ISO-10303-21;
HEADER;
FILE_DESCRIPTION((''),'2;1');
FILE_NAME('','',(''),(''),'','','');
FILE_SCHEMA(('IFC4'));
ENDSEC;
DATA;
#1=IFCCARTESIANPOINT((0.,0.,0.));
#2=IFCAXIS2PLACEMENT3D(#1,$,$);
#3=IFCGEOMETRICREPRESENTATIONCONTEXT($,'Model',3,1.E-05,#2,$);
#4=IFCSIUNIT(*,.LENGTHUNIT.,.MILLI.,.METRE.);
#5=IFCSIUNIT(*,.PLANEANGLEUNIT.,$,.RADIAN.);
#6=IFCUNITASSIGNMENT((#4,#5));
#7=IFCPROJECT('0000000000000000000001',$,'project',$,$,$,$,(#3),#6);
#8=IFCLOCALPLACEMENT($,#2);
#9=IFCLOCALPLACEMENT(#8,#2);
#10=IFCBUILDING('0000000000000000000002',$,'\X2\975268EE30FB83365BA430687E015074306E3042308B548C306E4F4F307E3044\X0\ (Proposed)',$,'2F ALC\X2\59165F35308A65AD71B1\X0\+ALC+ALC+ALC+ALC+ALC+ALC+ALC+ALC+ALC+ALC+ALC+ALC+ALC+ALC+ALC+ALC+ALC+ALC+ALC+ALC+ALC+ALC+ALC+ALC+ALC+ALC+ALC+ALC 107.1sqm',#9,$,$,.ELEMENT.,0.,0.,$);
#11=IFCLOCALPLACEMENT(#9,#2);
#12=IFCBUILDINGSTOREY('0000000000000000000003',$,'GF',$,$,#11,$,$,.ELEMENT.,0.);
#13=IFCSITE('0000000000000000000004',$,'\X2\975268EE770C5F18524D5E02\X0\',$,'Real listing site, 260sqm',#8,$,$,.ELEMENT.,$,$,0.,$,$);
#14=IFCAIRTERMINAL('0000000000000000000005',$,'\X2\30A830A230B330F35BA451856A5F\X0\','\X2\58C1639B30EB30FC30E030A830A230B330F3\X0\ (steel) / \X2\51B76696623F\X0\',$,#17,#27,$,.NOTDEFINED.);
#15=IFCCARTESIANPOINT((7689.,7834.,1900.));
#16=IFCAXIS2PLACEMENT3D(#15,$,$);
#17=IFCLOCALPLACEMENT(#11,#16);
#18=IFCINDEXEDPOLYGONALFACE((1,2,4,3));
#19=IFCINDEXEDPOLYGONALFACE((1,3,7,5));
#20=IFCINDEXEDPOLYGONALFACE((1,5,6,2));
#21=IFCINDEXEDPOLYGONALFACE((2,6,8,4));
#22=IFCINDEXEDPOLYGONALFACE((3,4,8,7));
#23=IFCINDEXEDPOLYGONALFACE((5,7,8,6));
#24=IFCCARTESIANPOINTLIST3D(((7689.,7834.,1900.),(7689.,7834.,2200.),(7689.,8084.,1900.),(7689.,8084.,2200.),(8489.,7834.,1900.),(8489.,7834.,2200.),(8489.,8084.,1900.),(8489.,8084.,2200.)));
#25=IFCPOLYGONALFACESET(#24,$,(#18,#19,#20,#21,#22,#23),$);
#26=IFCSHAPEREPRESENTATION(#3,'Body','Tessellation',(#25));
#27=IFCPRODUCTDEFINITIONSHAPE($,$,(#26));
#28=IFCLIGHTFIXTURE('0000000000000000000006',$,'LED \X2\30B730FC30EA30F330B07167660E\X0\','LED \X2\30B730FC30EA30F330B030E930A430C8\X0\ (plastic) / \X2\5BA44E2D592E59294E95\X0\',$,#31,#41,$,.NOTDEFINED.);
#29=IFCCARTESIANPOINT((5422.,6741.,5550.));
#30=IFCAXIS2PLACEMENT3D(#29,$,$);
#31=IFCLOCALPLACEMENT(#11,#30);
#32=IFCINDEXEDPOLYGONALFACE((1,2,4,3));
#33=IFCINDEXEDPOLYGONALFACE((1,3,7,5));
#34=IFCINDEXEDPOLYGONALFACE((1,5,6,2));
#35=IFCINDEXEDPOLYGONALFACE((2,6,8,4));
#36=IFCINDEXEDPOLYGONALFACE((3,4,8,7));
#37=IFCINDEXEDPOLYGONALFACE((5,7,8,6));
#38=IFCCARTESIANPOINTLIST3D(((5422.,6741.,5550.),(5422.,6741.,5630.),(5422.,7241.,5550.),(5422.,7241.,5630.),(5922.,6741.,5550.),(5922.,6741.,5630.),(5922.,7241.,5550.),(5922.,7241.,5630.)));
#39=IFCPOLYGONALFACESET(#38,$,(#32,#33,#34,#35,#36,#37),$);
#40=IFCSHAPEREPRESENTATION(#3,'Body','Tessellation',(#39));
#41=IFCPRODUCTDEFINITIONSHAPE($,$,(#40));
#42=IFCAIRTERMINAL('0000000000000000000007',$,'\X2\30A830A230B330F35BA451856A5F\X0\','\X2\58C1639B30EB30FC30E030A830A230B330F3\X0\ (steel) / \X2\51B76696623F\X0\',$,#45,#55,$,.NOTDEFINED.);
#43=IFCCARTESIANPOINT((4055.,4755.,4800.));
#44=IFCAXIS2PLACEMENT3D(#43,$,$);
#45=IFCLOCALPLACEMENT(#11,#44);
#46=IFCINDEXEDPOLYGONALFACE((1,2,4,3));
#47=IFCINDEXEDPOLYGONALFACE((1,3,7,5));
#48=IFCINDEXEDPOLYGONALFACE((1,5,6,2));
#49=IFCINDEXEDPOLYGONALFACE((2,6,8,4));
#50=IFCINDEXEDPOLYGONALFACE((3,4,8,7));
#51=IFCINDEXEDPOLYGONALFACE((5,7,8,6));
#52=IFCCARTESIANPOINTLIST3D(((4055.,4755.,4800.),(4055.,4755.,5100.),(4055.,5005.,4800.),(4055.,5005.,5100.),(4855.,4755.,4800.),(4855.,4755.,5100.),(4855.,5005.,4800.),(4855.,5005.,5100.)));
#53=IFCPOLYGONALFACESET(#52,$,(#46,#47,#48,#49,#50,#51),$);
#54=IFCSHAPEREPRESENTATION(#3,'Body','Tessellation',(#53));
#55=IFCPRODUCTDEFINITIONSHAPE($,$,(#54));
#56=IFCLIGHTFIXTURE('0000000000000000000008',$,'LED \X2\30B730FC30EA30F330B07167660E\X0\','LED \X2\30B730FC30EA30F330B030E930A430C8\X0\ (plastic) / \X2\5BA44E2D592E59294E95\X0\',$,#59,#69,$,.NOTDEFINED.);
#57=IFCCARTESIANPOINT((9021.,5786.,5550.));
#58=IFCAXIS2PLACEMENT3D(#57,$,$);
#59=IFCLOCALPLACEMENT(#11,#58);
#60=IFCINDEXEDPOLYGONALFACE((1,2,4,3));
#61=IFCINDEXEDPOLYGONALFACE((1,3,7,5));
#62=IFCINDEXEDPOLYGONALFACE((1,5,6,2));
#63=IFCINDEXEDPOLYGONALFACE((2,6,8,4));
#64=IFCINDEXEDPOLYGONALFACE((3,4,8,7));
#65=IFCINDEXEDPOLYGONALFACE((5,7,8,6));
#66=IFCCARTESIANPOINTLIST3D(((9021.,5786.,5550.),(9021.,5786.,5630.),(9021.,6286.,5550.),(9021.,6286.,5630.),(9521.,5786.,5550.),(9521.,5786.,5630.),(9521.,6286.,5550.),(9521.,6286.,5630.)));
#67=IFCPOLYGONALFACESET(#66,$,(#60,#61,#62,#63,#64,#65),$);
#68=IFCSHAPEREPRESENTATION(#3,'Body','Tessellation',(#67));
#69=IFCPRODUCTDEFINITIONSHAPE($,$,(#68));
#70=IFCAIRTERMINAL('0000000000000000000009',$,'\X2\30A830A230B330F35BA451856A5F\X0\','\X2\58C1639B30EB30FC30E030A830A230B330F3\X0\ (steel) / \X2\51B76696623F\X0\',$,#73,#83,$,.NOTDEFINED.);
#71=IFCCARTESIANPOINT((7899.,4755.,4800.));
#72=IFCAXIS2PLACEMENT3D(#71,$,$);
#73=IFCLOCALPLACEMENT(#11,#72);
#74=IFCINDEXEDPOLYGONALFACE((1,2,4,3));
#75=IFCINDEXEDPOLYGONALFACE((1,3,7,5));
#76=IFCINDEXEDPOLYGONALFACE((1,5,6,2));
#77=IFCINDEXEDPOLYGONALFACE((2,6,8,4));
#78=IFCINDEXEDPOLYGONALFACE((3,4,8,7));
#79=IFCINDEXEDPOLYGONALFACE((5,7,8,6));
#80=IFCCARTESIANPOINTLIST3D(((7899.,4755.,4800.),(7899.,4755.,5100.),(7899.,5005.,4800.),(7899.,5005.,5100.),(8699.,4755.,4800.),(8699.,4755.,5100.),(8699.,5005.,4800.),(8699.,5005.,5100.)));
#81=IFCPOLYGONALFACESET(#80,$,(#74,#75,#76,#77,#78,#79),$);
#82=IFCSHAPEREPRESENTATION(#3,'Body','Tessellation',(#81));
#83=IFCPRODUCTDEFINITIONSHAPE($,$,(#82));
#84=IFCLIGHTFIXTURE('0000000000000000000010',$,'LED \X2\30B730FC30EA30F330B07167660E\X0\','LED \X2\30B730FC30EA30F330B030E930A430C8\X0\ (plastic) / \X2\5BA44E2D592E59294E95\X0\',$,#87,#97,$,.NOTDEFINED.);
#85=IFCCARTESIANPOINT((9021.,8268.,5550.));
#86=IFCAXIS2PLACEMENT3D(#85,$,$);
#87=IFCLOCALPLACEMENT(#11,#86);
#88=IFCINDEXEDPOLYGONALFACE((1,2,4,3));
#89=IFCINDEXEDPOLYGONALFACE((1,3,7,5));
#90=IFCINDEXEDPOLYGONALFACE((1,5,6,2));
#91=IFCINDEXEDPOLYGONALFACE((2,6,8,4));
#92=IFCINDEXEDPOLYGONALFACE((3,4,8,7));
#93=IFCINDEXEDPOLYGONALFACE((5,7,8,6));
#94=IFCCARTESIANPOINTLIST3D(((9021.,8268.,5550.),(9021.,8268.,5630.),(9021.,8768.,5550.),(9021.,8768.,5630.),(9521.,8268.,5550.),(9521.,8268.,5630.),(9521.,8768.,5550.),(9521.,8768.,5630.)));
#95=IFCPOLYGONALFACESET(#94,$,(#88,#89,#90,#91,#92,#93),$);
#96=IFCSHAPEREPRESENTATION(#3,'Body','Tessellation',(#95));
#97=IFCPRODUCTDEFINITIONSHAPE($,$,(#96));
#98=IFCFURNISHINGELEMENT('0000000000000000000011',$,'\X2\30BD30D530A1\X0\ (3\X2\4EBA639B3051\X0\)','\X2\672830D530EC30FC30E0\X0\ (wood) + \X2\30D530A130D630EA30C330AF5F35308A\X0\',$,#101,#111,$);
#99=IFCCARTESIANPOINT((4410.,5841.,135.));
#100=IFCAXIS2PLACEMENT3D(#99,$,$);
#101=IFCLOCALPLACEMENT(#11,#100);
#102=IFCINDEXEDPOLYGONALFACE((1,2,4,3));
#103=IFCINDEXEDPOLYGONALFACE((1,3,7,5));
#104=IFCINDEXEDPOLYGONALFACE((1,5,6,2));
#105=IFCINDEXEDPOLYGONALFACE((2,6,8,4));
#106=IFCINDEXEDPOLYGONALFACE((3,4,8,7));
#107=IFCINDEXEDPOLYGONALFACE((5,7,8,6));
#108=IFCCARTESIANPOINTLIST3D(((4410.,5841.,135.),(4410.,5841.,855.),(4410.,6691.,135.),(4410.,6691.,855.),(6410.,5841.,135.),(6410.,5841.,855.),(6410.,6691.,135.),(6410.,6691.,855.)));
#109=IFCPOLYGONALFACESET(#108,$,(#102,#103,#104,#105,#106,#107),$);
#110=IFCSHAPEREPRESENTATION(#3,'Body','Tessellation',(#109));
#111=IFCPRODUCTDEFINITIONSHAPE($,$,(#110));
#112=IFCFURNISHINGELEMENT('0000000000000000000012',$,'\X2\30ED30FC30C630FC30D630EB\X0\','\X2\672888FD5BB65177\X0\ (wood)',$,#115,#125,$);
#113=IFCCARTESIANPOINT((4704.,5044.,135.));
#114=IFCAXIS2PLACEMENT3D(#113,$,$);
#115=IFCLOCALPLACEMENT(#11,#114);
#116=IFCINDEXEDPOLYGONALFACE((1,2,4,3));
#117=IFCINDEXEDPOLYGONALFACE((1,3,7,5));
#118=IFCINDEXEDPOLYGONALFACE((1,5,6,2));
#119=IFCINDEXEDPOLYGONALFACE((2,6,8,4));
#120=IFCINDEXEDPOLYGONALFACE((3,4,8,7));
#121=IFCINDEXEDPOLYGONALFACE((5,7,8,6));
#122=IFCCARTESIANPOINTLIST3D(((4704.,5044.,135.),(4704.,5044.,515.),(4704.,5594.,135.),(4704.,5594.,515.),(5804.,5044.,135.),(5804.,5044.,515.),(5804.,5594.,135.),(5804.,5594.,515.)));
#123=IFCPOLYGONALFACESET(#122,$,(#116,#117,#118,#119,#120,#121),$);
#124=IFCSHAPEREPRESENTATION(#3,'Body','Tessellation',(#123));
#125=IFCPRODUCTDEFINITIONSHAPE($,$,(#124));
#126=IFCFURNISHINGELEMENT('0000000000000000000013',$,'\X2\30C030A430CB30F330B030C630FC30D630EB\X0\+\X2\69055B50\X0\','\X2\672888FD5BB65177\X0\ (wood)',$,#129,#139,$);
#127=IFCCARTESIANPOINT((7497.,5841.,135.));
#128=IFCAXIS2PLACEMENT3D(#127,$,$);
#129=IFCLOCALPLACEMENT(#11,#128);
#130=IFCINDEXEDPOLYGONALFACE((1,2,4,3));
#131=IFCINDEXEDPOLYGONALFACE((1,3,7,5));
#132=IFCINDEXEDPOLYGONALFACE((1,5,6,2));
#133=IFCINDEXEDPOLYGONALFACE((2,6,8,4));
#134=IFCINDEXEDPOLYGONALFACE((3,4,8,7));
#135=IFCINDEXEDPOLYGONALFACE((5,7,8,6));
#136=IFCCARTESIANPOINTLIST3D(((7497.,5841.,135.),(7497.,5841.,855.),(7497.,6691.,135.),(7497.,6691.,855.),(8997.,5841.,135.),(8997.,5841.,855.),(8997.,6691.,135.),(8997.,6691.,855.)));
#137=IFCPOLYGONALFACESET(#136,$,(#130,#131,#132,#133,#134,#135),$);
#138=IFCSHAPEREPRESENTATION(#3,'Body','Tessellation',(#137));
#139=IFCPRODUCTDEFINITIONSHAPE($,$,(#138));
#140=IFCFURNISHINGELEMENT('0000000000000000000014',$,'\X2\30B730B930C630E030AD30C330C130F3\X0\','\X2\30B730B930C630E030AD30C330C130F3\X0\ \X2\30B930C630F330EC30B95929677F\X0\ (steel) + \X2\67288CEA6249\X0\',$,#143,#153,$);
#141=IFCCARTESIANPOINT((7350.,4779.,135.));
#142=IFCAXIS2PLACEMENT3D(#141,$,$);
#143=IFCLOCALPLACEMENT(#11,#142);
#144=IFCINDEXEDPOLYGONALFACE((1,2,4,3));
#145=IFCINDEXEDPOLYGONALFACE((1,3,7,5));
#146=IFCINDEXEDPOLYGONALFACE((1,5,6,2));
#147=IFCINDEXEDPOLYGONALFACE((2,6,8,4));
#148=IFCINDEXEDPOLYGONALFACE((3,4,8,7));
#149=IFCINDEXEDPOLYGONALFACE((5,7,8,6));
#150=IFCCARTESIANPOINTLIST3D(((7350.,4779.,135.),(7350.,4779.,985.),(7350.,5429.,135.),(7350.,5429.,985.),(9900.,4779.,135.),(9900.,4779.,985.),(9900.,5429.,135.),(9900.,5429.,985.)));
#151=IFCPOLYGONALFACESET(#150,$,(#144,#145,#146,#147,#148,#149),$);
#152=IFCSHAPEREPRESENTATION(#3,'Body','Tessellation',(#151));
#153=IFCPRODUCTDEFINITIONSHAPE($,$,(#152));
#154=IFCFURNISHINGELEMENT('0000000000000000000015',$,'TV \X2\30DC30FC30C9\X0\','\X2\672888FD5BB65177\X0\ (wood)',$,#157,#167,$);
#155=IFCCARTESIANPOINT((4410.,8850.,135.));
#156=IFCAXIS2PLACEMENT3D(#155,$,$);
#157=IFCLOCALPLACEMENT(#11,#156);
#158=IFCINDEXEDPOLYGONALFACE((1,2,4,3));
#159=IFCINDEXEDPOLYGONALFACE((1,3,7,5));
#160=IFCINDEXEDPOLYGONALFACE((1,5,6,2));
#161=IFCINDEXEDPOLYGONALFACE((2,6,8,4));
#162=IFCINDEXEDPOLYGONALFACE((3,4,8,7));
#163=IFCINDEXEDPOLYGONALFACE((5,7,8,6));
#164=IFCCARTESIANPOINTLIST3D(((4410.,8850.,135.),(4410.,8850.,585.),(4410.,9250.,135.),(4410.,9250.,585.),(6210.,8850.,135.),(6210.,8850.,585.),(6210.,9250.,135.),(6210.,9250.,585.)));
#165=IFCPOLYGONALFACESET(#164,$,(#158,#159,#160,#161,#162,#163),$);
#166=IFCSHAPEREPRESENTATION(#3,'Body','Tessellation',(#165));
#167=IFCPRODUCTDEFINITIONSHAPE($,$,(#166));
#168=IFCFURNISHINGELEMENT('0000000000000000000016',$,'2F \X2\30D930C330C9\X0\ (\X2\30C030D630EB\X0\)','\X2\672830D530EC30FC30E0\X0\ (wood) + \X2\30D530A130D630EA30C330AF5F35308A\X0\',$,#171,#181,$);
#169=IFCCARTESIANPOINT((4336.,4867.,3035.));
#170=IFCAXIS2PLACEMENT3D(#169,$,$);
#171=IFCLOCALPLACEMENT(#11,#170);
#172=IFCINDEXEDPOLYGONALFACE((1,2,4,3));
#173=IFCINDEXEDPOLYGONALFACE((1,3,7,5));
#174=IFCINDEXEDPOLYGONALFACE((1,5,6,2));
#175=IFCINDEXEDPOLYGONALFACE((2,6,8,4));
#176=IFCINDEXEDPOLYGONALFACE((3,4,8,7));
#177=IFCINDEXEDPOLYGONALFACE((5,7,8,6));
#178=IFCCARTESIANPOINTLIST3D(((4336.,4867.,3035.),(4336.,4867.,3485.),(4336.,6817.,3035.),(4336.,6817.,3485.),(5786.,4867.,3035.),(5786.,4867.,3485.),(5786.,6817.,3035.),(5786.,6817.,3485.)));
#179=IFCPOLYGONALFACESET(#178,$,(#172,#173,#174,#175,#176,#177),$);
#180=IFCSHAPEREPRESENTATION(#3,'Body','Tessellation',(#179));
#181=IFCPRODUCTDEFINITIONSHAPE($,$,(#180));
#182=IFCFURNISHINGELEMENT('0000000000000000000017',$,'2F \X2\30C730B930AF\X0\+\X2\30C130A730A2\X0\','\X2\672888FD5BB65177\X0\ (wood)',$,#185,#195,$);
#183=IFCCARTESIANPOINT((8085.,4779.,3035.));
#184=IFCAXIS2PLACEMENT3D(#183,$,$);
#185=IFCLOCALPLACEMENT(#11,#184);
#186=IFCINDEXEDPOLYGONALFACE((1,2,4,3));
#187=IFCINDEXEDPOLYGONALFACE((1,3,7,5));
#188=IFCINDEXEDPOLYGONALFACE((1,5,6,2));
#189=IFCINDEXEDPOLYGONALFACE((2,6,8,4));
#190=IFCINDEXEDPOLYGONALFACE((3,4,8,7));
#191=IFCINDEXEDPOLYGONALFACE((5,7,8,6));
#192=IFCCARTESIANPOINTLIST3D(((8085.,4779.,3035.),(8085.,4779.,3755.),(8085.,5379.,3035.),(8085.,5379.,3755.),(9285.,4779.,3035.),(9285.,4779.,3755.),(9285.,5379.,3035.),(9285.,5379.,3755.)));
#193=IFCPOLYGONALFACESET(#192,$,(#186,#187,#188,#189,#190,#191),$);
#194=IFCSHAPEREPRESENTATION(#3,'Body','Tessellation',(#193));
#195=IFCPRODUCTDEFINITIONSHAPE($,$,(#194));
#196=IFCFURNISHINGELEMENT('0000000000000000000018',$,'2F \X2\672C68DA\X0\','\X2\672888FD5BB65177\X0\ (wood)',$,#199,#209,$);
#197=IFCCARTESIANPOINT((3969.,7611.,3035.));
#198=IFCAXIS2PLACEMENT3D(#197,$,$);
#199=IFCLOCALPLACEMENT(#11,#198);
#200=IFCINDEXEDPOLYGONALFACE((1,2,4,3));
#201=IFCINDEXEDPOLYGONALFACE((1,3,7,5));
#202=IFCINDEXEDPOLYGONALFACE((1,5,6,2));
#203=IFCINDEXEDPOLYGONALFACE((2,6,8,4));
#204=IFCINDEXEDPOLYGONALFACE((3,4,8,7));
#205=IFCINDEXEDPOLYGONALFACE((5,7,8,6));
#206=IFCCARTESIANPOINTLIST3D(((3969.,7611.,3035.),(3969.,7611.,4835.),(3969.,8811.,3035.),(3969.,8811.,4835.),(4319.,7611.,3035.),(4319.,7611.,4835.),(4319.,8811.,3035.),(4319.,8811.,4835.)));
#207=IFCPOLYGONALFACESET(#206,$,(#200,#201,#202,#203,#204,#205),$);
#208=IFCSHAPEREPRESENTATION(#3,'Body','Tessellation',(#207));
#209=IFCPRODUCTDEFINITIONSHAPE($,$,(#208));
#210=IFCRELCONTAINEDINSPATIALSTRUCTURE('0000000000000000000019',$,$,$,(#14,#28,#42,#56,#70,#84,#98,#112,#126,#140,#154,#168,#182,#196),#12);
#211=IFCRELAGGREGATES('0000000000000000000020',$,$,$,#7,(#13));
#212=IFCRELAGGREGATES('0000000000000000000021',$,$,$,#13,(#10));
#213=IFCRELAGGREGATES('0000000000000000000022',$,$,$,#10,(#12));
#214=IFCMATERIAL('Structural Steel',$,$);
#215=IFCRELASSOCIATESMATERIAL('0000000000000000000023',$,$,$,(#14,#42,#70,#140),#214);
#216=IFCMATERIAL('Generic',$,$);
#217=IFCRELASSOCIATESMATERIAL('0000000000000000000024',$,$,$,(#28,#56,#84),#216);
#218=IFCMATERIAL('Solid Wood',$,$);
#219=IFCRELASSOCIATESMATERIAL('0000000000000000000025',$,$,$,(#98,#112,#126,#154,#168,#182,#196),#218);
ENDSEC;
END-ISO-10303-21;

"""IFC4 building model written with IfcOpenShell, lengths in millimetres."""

from ifc_helpers import new_model, si_unit, frame, frame_2d, origin, place, context, project, spatial, rectangle, extrude, material, element, save


model = new_model("IFC4")

# Units and contexts
model_context = context("Model", 3, precision=1e-05, world=origin())
ifc_project = project(units=[si_unit("LENGTHUNIT", "METRE", prefix="MILLI"), si_unit("PLANEANGLEUNIT", "RADIAN")], contexts=[model_context])

# Site, building, storey
site_placement = place(None, origin())
site = spatial("IfcSite", under=ifc_project, at=site_placement, Name="青森県弘前市", ObjectType="Real listing site, 260sqm", CompositionType="ELEMENT", RefElevation=0.0)
building_placement = place(site_placement, origin())
building = spatial("IfcBuilding", under=site, at=building_placement, Name="青森・茶室と縁側のある和の住まい (Proposed)", ObjectType="2F ALC外張り断熱+ALC+ALC+ALC+ALC+ALC+ALC+ALC+ALC+ALC+ALC+ALC+ALC+ALC+ALC+ALC+ALC+ALC+ALC+ALC+ALC+ALC+ALC+ALC+ALC+ALC+ALC+ALC+ALC 107.1sqm", CompositionType="ELEMENT", ElevationOfRefHeight=0.0, ElevationOfTerrain=0.0)
storey_placement = place(building_placement, origin())
storey = spatial("IfcBuildingStorey", under=building, at=storey_placement, Name="GF", CompositionType="ELEMENT", Elevation=0.0)

# Shared definitions
ifc_material_1 = material(Name="Solid Wood")

# Shared definitions
ifc_material_2 = material(Name="Structural Steel")

# Shared definitions
ifc_material_3 = material(Name="Generic")

# Air terminal
air_terminal_1_placement = place(storey_placement, frame((7689.0, 7834.0, 1900.0)))
element("IfcAirTerminal", 1, at=air_terminal_1_placement, inside=storey, material=ifc_material_2, Name="エアコン室内機", Description="壁掛ルームエアコン (steel) / 冷暖房", PredefinedType="NOTDEFINED", context=model_context, shape_type="SweptSolid", body=[
    extrude(rectangle(XDim=800.0, YDim=250.0, at=frame_2d((400.0, 125.0))), frame((7689.0, 7834.0, 1900.0)), (0.0, 0.0, 1.0), 300.0),
])

# Light fixture
light_fixture_1_placement = place(storey_placement, frame((5422.0, 6741.0, 5550.0)))
element("IfcLightFixture", 2, at=light_fixture_1_placement, inside=storey, material=ifc_material_3, Name="LED シーリング照明", Description="LED シーリングライト (plastic) / 室中央天井", PredefinedType="NOTDEFINED", context=model_context, shape_type="SweptSolid", body=[
    extrude(rectangle(XDim=500.0, YDim=500.0, at=frame_2d((250.0, 250.0))), frame((5422.0, 6741.0, 5550.0)), (0.0, 0.0, 1.0), 80.0),
])

# Air terminal
air_terminal_2_placement = place(storey_placement, frame((4055.0, 4755.0, 4800.0)))
element("IfcAirTerminal", 3, at=air_terminal_2_placement, inside=storey, material=ifc_material_2, Name="エアコン室内機", Description="壁掛ルームエアコン (steel) / 冷暖房", PredefinedType="NOTDEFINED", context=model_context, shape_type="SweptSolid", body=[
    extrude(rectangle(XDim=800.0, YDim=250.0, at=frame_2d((400.0, 125.0))), frame((4055.0, 4755.0, 4800.0)), (0.0, 0.0, 1.0), 300.0),
])

# Light fixture
light_fixture_2_placement = place(storey_placement, frame((9021.0, 5786.0, 5550.0)))
element("IfcLightFixture", 4, at=light_fixture_2_placement, inside=storey, material=ifc_material_3, Name="LED シーリング照明", Description="LED シーリングライト (plastic) / 室中央天井", PredefinedType="NOTDEFINED", context=model_context, shape_type="SweptSolid", body=[
    extrude(rectangle(XDim=500.0, YDim=500.0, at=frame_2d((250.0, 250.0))), frame((9021.0, 5786.0, 5550.0)), (0.0, 0.0, 1.0), 80.0),
])

# Air terminal
air_terminal_3_placement = place(storey_placement, frame((7899.0, 4755.0, 4800.0)))
element("IfcAirTerminal", 5, at=air_terminal_3_placement, inside=storey, material=ifc_material_2, Name="エアコン室内機", Description="壁掛ルームエアコン (steel) / 冷暖房", PredefinedType="NOTDEFINED", context=model_context, shape_type="SweptSolid", body=[
    extrude(rectangle(XDim=800.0, YDim=250.0, at=frame_2d((400.0, 125.0))), frame((7899.0, 4755.0, 4800.0)), (0.0, 0.0, 1.0), 300.0),
])

# Light fixture
light_fixture_3_placement = place(storey_placement, frame((9021.0, 8268.0, 5550.0)))
element("IfcLightFixture", 6, at=light_fixture_3_placement, inside=storey, material=ifc_material_3, Name="LED シーリング照明", Description="LED シーリングライト (plastic) / 室中央天井", PredefinedType="NOTDEFINED", context=model_context, shape_type="SweptSolid", body=[
    extrude(rectangle(XDim=500.0, YDim=500.0, at=frame_2d((250.0, 250.0))), frame((9021.0, 8268.0, 5550.0)), (0.0, 0.0, 1.0), 80.0),
])

# Furnishing elements
furnishing_1_placement = place(storey_placement, frame((4410.0, 5841.0, 135.0)))
element("IfcFurnishingElement", 7, at=furnishing_1_placement, inside=storey, material=ifc_material_1, Name="ソファ (3人掛け)", Description="木フレーム (wood) + ファブリック張り", context=model_context, shape_type="SweptSolid", body=[
    extrude(rectangle(XDim=2000.0, YDim=850.0, at=frame_2d((1000.0, 425.0))), frame((4410.0, 5841.0, 135.0)), (0.0, 0.0, 1.0), 720.0),
])
furnishing_2_placement = place(storey_placement, frame((4704.0, 5044.0, 135.0)))
element("IfcFurnishingElement", 8, at=furnishing_2_placement, inside=storey, material=ifc_material_1, Name="ローテーブル", Description="木製家具 (wood)", context=model_context, shape_type="SweptSolid", body=[
    extrude(rectangle(XDim=1100.0, YDim=550.0, at=frame_2d((550.0, 275.0))), frame((4704.0, 5044.0, 135.0)), (0.0, 0.0, 1.0), 380.0),
])
furnishing_3_placement = place(storey_placement, frame((7497.0, 5841.0, 135.0)))
element("IfcFurnishingElement", 9, at=furnishing_3_placement, inside=storey, material=ifc_material_1, Name="ダイニングテーブル+椅子", Description="木製家具 (wood)", context=model_context, shape_type="SweptSolid", body=[
    extrude(rectangle(XDim=1500.0, YDim=850.0, at=frame_2d((750.0, 425.0))), frame((7497.0, 5841.0, 135.0)), (0.0, 0.0, 1.0), 720.0),
])
furnishing_4_placement = place(storey_placement, frame((7350.0, 4779.0, 135.0)))
element("IfcFurnishingElement", 10, at=furnishing_4_placement, inside=storey, material=ifc_material_2, Name="システムキッチン", Description="システムキッチン ステンレス天板 (steel) + 木質扉", context=model_context, shape_type="SweptSolid", body=[
    extrude(rectangle(XDim=2550.0, YDim=650.0, at=frame_2d((1275.0, 325.0))), frame((7350.0, 4779.0, 135.0)), (0.0, 0.0, 1.0), 850.0),
])
furnishing_5_placement = place(storey_placement, frame((4410.0, 8850.0, 135.0)))
element("IfcFurnishingElement", 11, at=furnishing_5_placement, inside=storey, material=ifc_material_1, Name="TV ボード", Description="木製家具 (wood)", context=model_context, shape_type="SweptSolid", body=[
    extrude(rectangle(XDim=1800.0, YDim=400.0, at=frame_2d((900.0, 200.0))), frame((4410.0, 8850.0, 135.0)), (0.0, 0.0, 1.0), 450.0),
])
furnishing_6_placement = place(storey_placement, frame((4336.0, 4867.0, 3035.0)))
element("IfcFurnishingElement", 12, at=furnishing_6_placement, inside=storey, material=ifc_material_1, Name="2F ベッド (ダブル)", Description="木フレーム (wood) + ファブリック張り", context=model_context, shape_type="SweptSolid", body=[
    extrude(rectangle(XDim=1450.0, YDim=1950.0, at=frame_2d((725.0, 975.0))), frame((4336.0, 4867.0, 3035.0)), (0.0, 0.0, 1.0), 450.0),
])
furnishing_7_placement = place(storey_placement, frame((8085.0, 4779.0, 3035.0)))
element("IfcFurnishingElement", 13, at=furnishing_7_placement, inside=storey, material=ifc_material_1, Name="2F デスク+チェア", Description="木製家具 (wood)", context=model_context, shape_type="SweptSolid", body=[
    extrude(rectangle(XDim=1200.0, YDim=600.0, at=frame_2d((600.0, 300.0))), frame((8085.0, 4779.0, 3035.0)), (0.0, 0.0, 1.0), 720.0),
])
furnishing_8_placement = place(storey_placement, frame((3969.0, 7611.0, 3035.0)))
element("IfcFurnishingElement", 14, at=furnishing_8_placement, inside=storey, material=ifc_material_1, Name="2F 本棚", Description="木製家具 (wood)", context=model_context, shape_type="SweptSolid", body=[
    extrude(rectangle(XDim=350.0, YDim=1200.0, at=frame_2d((175.0, 600.0))), frame((3969.0, 7611.0, 3035.0)), (0.0, 0.0, 1.0), 1800.0),
])

save(model, "model.ifc")
